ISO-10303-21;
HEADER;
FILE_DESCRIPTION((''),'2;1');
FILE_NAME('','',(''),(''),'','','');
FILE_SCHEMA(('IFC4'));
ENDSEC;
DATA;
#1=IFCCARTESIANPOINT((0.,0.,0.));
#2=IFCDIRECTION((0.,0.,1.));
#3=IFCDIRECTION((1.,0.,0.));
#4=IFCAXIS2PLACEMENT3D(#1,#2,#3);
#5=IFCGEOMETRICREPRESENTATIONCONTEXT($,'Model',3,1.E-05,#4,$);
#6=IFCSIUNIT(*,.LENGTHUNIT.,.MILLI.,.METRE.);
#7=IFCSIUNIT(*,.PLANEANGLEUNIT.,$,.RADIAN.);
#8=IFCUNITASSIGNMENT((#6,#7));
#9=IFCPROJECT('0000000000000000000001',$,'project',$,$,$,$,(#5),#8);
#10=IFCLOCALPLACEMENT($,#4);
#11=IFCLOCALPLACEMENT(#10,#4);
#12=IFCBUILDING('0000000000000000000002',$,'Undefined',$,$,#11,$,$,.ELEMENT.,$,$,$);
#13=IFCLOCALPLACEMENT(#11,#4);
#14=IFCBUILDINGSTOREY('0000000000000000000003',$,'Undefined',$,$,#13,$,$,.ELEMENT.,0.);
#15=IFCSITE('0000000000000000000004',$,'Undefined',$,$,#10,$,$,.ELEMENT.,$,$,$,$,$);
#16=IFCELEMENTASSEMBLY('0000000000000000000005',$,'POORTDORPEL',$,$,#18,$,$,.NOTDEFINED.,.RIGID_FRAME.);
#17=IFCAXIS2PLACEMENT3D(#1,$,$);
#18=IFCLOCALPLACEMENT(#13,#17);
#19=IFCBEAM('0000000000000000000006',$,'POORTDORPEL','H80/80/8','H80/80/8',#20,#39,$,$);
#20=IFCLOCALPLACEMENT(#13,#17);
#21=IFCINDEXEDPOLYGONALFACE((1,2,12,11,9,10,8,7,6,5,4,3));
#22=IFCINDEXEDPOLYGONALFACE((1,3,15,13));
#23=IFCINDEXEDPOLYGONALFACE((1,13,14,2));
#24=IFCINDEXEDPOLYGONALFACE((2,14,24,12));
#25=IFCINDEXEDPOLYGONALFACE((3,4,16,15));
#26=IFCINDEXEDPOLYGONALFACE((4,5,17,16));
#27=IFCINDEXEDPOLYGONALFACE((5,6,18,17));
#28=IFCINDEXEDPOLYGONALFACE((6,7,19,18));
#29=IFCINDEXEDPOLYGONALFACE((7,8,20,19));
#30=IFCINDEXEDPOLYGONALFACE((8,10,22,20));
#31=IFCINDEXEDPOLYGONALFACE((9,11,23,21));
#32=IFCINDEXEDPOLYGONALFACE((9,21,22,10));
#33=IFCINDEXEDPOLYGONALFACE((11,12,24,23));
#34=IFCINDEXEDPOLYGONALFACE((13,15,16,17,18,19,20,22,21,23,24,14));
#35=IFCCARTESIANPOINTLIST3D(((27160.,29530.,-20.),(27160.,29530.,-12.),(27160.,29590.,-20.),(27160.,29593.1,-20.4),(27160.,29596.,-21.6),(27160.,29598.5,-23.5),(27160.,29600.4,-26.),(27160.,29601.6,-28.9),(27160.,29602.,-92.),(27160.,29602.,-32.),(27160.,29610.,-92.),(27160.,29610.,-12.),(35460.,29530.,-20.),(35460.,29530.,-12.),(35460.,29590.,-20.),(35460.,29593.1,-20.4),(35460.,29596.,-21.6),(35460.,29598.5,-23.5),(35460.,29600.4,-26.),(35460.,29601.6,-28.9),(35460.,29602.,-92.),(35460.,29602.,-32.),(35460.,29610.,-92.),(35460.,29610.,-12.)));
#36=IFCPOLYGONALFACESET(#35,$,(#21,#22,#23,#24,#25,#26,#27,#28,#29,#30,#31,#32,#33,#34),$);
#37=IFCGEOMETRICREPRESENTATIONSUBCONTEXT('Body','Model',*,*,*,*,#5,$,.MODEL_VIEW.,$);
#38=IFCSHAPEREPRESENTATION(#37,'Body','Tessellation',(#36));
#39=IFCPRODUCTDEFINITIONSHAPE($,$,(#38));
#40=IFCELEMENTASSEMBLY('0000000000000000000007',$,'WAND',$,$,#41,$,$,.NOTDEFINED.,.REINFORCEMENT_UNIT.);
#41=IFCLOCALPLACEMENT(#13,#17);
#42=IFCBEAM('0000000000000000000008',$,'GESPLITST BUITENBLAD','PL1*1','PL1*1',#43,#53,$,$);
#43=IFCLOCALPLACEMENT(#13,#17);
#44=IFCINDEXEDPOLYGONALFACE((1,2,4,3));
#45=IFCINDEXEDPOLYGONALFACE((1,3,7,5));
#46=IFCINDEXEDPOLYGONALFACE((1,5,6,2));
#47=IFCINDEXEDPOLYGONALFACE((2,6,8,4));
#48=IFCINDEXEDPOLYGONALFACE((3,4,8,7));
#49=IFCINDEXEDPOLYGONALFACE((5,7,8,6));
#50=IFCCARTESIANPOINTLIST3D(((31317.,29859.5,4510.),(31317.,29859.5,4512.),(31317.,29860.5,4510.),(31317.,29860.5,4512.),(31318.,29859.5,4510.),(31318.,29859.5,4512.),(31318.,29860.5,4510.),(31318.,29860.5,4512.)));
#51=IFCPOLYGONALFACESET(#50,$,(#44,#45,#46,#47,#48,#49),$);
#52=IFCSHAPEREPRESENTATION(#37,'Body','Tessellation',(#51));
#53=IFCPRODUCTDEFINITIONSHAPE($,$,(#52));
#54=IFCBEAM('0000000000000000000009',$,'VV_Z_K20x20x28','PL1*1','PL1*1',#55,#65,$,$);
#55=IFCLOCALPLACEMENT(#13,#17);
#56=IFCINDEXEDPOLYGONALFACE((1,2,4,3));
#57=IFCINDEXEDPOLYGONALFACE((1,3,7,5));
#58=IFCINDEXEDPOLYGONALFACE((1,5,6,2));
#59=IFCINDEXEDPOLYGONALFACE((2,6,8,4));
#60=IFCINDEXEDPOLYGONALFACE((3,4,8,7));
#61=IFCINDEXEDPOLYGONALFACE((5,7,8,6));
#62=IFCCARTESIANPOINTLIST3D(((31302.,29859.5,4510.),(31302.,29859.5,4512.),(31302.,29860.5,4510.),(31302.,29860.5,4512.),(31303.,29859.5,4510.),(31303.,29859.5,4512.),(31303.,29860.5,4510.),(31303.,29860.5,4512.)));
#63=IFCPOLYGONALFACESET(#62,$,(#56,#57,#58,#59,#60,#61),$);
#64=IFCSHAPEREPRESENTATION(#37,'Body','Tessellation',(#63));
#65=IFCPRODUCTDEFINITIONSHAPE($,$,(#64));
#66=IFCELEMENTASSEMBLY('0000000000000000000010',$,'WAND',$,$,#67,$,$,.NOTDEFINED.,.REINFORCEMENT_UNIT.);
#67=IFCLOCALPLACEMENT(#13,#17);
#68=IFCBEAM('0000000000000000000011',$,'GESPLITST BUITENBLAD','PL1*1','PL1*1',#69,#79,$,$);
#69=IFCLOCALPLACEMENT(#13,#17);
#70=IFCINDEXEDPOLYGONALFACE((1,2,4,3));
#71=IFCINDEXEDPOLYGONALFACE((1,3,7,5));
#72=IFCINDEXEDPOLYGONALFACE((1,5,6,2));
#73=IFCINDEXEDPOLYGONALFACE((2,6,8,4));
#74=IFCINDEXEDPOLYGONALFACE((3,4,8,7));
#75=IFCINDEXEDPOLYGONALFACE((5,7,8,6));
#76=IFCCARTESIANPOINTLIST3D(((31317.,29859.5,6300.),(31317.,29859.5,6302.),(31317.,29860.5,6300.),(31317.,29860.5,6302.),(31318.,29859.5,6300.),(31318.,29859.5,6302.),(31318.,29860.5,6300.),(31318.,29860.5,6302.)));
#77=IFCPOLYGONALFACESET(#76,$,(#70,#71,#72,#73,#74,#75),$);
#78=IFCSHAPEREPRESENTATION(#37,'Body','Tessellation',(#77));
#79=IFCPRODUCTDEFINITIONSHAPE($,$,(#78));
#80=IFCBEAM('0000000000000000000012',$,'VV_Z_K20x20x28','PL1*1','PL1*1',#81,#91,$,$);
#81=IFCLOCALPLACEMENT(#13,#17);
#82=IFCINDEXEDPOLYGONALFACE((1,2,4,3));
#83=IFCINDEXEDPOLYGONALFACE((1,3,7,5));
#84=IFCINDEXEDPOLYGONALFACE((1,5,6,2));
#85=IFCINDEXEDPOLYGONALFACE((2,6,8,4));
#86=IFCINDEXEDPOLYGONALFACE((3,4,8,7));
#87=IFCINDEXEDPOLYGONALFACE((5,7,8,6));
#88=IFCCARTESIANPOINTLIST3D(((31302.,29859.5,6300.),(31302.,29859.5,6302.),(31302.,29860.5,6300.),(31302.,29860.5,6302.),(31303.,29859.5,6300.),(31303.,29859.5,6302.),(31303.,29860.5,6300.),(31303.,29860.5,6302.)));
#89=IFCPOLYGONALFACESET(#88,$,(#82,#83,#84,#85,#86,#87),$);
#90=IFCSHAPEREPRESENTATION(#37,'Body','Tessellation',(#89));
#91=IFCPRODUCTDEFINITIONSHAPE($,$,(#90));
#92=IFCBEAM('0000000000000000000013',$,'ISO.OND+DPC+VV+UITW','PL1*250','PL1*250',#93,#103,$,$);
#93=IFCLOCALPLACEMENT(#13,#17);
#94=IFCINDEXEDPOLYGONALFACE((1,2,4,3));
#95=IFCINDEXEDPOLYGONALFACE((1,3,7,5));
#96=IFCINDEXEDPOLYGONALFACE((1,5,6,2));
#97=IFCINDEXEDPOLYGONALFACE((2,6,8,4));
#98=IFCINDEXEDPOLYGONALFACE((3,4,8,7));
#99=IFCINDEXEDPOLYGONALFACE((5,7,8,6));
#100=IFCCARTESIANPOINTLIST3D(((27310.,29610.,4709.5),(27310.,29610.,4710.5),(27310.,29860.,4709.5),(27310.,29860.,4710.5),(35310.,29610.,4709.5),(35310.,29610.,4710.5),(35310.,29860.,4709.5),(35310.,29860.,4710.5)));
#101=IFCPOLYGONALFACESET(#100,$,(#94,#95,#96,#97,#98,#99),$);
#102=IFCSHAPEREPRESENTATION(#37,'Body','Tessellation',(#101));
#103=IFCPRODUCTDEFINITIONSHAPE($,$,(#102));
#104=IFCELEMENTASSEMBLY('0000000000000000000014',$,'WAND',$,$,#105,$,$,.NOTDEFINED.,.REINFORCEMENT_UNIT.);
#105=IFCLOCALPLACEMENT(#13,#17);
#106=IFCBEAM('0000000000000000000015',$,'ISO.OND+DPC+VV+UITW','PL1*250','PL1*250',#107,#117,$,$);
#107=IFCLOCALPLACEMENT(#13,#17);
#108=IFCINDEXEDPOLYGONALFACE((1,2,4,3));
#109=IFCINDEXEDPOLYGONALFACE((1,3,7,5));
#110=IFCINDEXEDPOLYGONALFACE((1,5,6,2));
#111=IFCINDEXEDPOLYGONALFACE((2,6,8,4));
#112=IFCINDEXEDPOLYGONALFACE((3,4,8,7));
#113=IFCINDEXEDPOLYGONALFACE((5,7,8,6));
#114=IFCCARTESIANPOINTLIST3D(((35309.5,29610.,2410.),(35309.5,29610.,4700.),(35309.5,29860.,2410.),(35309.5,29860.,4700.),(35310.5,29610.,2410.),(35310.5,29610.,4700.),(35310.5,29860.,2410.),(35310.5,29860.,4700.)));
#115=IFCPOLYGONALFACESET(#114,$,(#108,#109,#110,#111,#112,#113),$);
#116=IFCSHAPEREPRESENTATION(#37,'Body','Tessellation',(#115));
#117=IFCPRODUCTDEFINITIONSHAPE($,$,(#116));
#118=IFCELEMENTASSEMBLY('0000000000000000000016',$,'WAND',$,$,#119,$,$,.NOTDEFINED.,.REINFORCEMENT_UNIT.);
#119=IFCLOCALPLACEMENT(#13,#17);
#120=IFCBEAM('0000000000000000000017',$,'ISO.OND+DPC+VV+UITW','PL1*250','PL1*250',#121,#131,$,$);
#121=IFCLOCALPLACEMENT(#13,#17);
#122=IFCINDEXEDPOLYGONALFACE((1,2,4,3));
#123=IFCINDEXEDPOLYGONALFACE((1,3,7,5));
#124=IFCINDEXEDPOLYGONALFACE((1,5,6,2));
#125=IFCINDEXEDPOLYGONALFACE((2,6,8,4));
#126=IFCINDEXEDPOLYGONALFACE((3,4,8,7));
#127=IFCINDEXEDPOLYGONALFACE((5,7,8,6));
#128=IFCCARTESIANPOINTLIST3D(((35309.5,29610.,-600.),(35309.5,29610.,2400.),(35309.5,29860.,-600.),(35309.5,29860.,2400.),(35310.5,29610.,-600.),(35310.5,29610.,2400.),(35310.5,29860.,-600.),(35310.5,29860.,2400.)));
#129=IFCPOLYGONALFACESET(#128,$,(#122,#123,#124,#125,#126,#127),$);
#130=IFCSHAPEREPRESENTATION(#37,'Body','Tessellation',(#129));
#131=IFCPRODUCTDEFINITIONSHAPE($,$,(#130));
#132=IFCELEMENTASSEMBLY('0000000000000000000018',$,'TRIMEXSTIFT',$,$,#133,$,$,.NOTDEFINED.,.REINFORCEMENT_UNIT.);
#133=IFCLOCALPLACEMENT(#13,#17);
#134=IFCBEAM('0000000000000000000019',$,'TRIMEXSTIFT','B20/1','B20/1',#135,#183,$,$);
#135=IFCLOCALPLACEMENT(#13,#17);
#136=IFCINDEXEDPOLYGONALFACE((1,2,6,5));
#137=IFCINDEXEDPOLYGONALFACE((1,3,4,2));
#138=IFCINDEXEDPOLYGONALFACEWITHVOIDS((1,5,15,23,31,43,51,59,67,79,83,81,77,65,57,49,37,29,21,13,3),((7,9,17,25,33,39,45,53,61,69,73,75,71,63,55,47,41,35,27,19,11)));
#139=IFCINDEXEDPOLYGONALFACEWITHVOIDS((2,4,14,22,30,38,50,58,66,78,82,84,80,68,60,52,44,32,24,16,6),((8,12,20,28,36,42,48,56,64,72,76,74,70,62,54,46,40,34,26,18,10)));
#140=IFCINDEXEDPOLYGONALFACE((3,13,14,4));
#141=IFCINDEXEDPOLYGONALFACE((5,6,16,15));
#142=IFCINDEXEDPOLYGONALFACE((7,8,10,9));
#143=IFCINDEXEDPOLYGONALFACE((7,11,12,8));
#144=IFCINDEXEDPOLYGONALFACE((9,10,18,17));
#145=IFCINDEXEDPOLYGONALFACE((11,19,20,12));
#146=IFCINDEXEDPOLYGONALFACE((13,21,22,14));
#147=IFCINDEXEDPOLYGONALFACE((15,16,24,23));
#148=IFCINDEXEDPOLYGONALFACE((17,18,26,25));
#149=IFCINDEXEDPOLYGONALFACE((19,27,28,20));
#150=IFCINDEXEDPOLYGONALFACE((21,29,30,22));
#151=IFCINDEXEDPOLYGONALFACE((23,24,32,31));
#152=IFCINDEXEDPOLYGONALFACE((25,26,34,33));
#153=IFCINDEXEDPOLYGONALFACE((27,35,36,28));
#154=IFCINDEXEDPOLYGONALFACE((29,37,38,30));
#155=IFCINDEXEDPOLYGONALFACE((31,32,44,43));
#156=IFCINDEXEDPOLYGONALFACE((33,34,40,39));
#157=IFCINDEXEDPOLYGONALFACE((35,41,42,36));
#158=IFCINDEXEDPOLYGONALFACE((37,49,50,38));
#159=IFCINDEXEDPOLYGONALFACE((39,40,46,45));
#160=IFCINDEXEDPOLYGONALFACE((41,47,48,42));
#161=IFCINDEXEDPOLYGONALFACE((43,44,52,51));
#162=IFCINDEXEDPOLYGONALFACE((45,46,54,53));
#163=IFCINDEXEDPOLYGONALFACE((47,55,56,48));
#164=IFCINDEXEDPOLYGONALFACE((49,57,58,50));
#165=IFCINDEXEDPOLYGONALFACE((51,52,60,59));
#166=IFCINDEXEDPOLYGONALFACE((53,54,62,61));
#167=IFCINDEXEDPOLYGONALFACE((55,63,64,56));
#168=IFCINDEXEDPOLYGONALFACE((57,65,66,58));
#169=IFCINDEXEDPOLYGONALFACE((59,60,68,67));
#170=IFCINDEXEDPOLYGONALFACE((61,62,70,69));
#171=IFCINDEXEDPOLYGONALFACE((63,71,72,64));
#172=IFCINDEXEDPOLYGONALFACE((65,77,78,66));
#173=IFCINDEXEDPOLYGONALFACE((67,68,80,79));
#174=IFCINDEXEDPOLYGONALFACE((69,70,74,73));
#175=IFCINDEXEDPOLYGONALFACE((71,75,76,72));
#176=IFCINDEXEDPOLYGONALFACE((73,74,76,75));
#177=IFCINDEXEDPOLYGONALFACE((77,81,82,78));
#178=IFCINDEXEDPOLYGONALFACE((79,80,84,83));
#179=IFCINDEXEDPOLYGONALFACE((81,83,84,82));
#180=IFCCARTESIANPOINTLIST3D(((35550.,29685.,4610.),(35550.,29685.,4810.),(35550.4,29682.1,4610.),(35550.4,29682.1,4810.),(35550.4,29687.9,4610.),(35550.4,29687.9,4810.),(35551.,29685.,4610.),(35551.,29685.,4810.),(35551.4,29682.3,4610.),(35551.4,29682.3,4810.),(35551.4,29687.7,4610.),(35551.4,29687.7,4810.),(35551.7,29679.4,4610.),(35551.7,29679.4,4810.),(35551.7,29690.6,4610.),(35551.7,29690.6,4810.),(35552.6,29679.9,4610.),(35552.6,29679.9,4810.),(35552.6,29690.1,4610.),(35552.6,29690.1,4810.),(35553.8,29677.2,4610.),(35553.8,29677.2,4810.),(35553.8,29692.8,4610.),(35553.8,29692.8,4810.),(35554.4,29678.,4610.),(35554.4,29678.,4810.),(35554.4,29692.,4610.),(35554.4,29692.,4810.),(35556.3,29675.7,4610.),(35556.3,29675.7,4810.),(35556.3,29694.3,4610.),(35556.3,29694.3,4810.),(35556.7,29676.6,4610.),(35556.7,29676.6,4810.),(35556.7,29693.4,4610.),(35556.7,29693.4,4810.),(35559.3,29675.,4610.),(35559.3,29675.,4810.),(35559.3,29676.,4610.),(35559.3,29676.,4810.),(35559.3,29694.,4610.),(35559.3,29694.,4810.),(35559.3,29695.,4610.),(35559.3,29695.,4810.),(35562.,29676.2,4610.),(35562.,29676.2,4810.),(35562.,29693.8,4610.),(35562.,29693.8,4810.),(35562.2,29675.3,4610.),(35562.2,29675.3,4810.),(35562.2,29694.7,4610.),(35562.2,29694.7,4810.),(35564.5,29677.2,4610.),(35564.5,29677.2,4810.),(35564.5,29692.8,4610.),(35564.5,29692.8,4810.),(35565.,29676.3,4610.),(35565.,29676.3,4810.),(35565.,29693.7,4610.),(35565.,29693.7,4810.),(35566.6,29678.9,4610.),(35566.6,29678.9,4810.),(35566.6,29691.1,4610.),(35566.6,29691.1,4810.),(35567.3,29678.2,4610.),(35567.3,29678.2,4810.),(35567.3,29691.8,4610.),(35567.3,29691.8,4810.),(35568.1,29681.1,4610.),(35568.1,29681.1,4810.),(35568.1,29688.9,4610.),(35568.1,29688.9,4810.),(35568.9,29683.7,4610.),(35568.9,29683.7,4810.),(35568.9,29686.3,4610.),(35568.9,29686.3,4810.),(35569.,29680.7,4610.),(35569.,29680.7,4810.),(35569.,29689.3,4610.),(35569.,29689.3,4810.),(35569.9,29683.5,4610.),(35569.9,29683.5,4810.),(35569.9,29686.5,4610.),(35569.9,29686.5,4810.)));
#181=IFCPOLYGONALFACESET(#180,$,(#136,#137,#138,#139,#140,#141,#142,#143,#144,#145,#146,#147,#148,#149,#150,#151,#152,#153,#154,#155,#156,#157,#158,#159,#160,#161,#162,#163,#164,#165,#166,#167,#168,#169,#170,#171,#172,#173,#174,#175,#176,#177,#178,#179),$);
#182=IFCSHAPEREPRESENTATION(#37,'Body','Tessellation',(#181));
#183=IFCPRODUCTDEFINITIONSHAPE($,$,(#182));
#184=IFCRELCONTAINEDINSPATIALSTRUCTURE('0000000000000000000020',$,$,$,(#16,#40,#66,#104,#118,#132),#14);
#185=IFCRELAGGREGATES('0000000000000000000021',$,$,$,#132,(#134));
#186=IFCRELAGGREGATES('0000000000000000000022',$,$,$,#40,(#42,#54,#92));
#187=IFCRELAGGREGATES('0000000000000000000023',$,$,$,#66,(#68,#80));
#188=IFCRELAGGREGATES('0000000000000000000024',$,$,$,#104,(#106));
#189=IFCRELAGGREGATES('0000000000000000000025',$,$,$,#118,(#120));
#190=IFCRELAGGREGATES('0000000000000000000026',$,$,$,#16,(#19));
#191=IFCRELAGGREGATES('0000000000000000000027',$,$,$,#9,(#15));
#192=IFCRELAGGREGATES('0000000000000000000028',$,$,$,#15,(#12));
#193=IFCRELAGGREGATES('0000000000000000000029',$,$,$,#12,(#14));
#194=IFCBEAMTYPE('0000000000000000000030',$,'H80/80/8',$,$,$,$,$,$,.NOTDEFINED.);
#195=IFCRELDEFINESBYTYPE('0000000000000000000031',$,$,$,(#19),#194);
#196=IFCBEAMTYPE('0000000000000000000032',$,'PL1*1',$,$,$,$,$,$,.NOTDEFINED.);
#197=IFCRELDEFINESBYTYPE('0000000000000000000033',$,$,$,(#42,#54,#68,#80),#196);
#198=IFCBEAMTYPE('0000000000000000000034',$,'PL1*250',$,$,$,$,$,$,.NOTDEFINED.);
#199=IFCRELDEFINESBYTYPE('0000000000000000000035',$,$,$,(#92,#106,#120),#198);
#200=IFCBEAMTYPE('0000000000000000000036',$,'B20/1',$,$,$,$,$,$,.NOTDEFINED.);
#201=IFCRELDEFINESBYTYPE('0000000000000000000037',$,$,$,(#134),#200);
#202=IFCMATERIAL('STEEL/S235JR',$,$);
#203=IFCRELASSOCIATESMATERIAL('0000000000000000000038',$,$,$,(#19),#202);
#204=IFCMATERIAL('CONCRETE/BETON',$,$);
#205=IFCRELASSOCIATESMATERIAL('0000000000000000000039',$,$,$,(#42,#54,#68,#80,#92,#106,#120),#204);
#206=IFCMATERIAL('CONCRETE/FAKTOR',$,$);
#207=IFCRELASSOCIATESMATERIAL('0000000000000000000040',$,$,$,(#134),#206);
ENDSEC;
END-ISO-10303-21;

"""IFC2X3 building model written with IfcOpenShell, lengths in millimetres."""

from ifc_helpers import new_model, si_unit, frame, frame_2d, origin_with_axes, place, context, subcontext, project, spatial, rectangle, hollow_circle, l_section, extrude, material, type_object, element, aggregate, save


model = new_model("IFC2X3")

# Units and contexts
model_context = context("Model", 3, precision=1e-05, world=origin_with_axes())
body_context = subcontext(model_context, "Body", "Model", "MODEL_VIEW")
ifc_project = project(units=[si_unit("LENGTHUNIT", "METRE", prefix="MILLI"), si_unit("PLANEANGLEUNIT", "RADIAN")], contexts=[model_context])

# Site, building, storey
site_placement = place(None, origin_with_axes())
site = spatial("IfcSite", under=ifc_project, at=site_placement, Name="Undefined", CompositionType="ELEMENT")
building_placement = place(site_placement, origin_with_axes())
building = spatial("IfcBuilding", under=site, at=building_placement, Name="Undefined", CompositionType="ELEMENT")
storey_placement = place(building_placement, origin_with_axes())
storey = spatial("IfcBuildingStorey", under=building, at=storey_placement, Name="Undefined", CompositionType="ELEMENT", Elevation=0.0)

# Element assembly, beam
assembly_1_placement = place(storey_placement, origin_with_axes())
assembly_1 = element("IfcElementAssembly", 1, at=assembly_1_placement, inside=storey, Name="POORTDORPEL", AssemblyPlace="NOTDEFINED", PredefinedType="RIGID_FRAME")
ifc_material_1 = material(Name="STEEL/S235JR")
beam_type_1 = type_object("IfcBeamType", Name="H80/80/8", PredefinedType="NOTDEFINED")
beam_1_placement = place(assembly_1_placement, frame((35460.0, 29570.0, -52.0), z_axis=(0.0, 0.0, -1.0), x_axis=(-1.0, 0.0, 0.0)))
beam_1 = element("IfcBeam", 2, at=beam_1_placement, type_object=beam_type_1, material=ifc_material_1, Name="POORTDORPEL", Description="H80/80/8", ObjectType="H80/80/8", context=body_context, shape_type="SweptSolid", body=[
    extrude(l_section(Depth=80.0, Width=80.0, Thickness=8.0, FilletRadius=12.0, at=frame_2d((0.0, 0.0), x_axis=(1.0, 0.0))), frame((8300.0, 0.0, 0.0), z_axis=(-1.0, 0.0, 0.0), x_axis=(0.0, -1.0, 0.0)), (0.0, 0.0, 1.0), 8300.0),
])

# Element assemblies, beams
assembly_2_placement = place(storey_placement, origin_with_axes())
assembly_2 = element("IfcElementAssembly", 3, at=assembly_2_placement, inside=storey, Name="WAND", AssemblyPlace="NOTDEFINED", PredefinedType="REINFORCEMENT_UNIT")
ifc_material_2 = material(Name="CONCRETE/BETON")
beam_type_2 = type_object("IfcBeamType", Name="PL1*1", PredefinedType="NOTDEFINED")
beam_2_placement = place(assembly_2_placement, frame((31317.5, 29860.0, 4510.0), z_axis=(1.0, 0.0, 0.0), x_axis=(0.0, 0.0, 1.0)))
beam_2 = element("IfcBeam", 4, at=beam_2_placement, type_object=beam_type_2, material=ifc_material_2, Name="GESPLITST BUITENBLAD", Description="PL1*1", ObjectType="PL1*1", context=body_context, shape_type="SweptSolid", body=[
    extrude(rectangle(XDim=1.0, YDim=1.0, at=frame_2d((0.0, 0.0), x_axis=(1.0, 0.0))), frame((2.0, 0.0, 0.0), z_axis=(-1.0, 0.0, 0.0), x_axis=(0.0, -1.0, 0.0)), (0.0, 0.0, 1.0), 2.0),
])
beam_3_placement = place(assembly_2_placement, frame((31302.5, 29860.0, 4510.0), z_axis=(1.0, 0.0, 0.0), x_axis=(0.0, 0.0, 1.0)))
beam_3 = element("IfcBeam", 5, at=beam_3_placement, type_object=beam_type_2, material=ifc_material_2, Name="VV_Z_K20x20x28", Description="PL1*1", ObjectType="PL1*1", context=body_context, shape_type="SweptSolid", body=[
    extrude(rectangle(XDim=1.0, YDim=1.0, at=frame_2d((0.0, 0.0), x_axis=(1.0, 0.0))), frame((2.0, 0.0, 0.0), z_axis=(-1.0, 0.0, 0.0), x_axis=(0.0, -1.0, 0.0)), (0.0, 0.0, 1.0), 2.0),
])
assembly_3_placement = place(storey_placement, origin_with_axes())
assembly_3 = element("IfcElementAssembly", 6, at=assembly_3_placement, inside=storey, Name="WAND", AssemblyPlace="NOTDEFINED", PredefinedType="REINFORCEMENT_UNIT")
beam_4_placement = place(assembly_3_placement, frame((31317.5, 29860.0, 6300.0), z_axis=(1.0, 0.0, 0.0), x_axis=(0.0, 0.0, 1.0)))
beam_4 = element("IfcBeam", 7, at=beam_4_placement, type_object=beam_type_2, material=ifc_material_2, Name="GESPLITST BUITENBLAD", Description="PL1*1", ObjectType="PL1*1", context=body_context, shape_type="SweptSolid", body=[
    extrude(rectangle(XDim=1.0, YDim=1.0, at=frame_2d((0.0, 0.0), x_axis=(1.0, 0.0))), frame((2.0, 0.0, 0.0), z_axis=(-1.0, 0.0, 0.0), x_axis=(0.0, -1.0, 0.0)), (0.0, 0.0, 1.0), 2.0),
])
beam_5_placement = place(assembly_3_placement, frame((31302.5, 29860.0, 6300.0), z_axis=(1.0, 0.0, 0.0), x_axis=(0.0, 0.0, 1.0)))
beam_5 = element("IfcBeam", 8, at=beam_5_placement, type_object=beam_type_2, material=ifc_material_2, Name="VV_Z_K20x20x28", Description="PL1*1", ObjectType="PL1*1", context=body_context, shape_type="SweptSolid", body=[
    extrude(rectangle(XDim=1.0, YDim=1.0, at=frame_2d((0.0, 0.0), x_axis=(1.0, 0.0))), frame((2.0, 0.0, 0.0), z_axis=(-1.0, 0.0, 0.0), x_axis=(0.0, -1.0, 0.0)), (0.0, 0.0, 1.0), 2.0),
])

# Beam
beam_type_3 = type_object("IfcBeamType", Name="PL1*250", PredefinedType="NOTDEFINED")
beam_6_placement = place(assembly_2_placement, frame((35310.0, 29735.0, 4710.0), z_axis=(0.0, 1.0, 0.0), x_axis=(-1.0, 0.0, 0.0)))
beam_6 = element("IfcBeam", 9, at=beam_6_placement, type_object=beam_type_3, material=ifc_material_2, Name="ISO.OND+DPC+VV+UITW", Description="PL1*250", ObjectType="PL1*250", context=body_context, shape_type="SweptSolid", body=[
    extrude(rectangle(XDim=1.0, YDim=250.0, at=frame_2d((0.0, 0.0), x_axis=(1.0, 0.0))), frame((8000.0, 0.0, 0.0), z_axis=(-1.0, 0.0, 0.0), x_axis=(0.0, -1.0, 0.0)), (0.0, 0.0, 1.0), 8000.0),
])

# Element assemblies, beams
assembly_4_placement = place(storey_placement, origin_with_axes())
assembly_4 = element("IfcElementAssembly", 10, at=assembly_4_placement, inside=storey, Name="WAND", AssemblyPlace="NOTDEFINED", PredefinedType="REINFORCEMENT_UNIT")
beam_7_placement = place(assembly_4_placement, frame((35310.0, 29735.0, 2410.0), z_axis=(0.0, 1.0, 0.0), x_axis=(0.0, 0.0, 1.0)))
beam_7 = element("IfcBeam", 11, at=beam_7_placement, type_object=beam_type_3, material=ifc_material_2, Name="ISO.OND+DPC+VV+UITW", Description="PL1*250", ObjectType="PL1*250", context=body_context, shape_type="SweptSolid", body=[
    extrude(rectangle(XDim=1.0, YDim=250.0, at=frame_2d((0.0, 0.0), x_axis=(1.0, 0.0))), frame((2290.0, 0.0, 0.0), z_axis=(-1.0, 0.0, 0.0), x_axis=(0.0, -1.0, 0.0)), (0.0, 0.0, 1.0), 2290.0),
])
assembly_5_placement = place(storey_placement, origin_with_axes())
assembly_5 = element("IfcElementAssembly", 12, at=assembly_5_placement, inside=storey, Name="WAND", AssemblyPlace="NOTDEFINED", PredefinedType="REINFORCEMENT_UNIT")
beam_8_placement = place(assembly_5_placement, frame((35310.0, 29735.0, -600.0), z_axis=(0.0, 1.0, 0.0), x_axis=(0.0, 0.0, 1.0)))
beam_8 = element("IfcBeam", 13, at=beam_8_placement, type_object=beam_type_3, material=ifc_material_2, Name="ISO.OND+DPC+VV+UITW", Description="PL1*250", ObjectType="PL1*250", context=body_context, shape_type="SweptSolid", body=[
    extrude(rectangle(XDim=1.0, YDim=250.0, at=frame_2d((0.0, 0.0), x_axis=(1.0, 0.0))), frame((3000.0, 0.0, 0.0), z_axis=(-1.0, 0.0, 0.0), x_axis=(0.0, -1.0, 0.0)), (0.0, 0.0, 1.0), 3000.0),
])
assembly_6_placement = place(storey_placement, origin_with_axes())
assembly_6 = element("IfcElementAssembly", 14, at=assembly_6_placement, inside=storey, Name="TRIMEXSTIFT", AssemblyPlace="NOTDEFINED", PredefinedType="REINFORCEMENT_UNIT")
ifc_material_3 = material(Name="CONCRETE/FAKTOR")
beam_type_4 = type_object("IfcBeamType", Name="B20/1", PredefinedType="NOTDEFINED")
beam_9_placement = place(assembly_6_placement, frame((35560.0, 29685.0, 4610.0), z_axis=(0.0, 1.0, 0.0), x_axis=(0.0, 0.0, 1.0)))
beam_9 = element("IfcBeam", 15, at=beam_9_placement, type_object=beam_type_4, material=ifc_material_3, Name="TRIMEXSTIFT", Description="B20/1", ObjectType="B20/1", context=body_context, shape_type="SweptSolid", body=[
    extrude(hollow_circle(Radius=10.0, WallThickness=1.0, at=frame_2d((0.0, 0.0), x_axis=(1.0, 0.0))), frame((200.0, 0.0, 0.0), z_axis=(-1.0, 0.0, 0.0), x_axis=(0.0, -1.0, 0.0)), (0.0, 0.0, 1.0), 200.0),
])
aggregate(assembly_6, [beam_9])

aggregate(assembly_2, [beam_2, beam_3, beam_6])

aggregate(assembly_3, [beam_4, beam_5])

aggregate(assembly_4, [beam_7])
aggregate(assembly_5, [beam_8])

aggregate(assembly_1, [beam_1])

save(model, "model.ifc")
